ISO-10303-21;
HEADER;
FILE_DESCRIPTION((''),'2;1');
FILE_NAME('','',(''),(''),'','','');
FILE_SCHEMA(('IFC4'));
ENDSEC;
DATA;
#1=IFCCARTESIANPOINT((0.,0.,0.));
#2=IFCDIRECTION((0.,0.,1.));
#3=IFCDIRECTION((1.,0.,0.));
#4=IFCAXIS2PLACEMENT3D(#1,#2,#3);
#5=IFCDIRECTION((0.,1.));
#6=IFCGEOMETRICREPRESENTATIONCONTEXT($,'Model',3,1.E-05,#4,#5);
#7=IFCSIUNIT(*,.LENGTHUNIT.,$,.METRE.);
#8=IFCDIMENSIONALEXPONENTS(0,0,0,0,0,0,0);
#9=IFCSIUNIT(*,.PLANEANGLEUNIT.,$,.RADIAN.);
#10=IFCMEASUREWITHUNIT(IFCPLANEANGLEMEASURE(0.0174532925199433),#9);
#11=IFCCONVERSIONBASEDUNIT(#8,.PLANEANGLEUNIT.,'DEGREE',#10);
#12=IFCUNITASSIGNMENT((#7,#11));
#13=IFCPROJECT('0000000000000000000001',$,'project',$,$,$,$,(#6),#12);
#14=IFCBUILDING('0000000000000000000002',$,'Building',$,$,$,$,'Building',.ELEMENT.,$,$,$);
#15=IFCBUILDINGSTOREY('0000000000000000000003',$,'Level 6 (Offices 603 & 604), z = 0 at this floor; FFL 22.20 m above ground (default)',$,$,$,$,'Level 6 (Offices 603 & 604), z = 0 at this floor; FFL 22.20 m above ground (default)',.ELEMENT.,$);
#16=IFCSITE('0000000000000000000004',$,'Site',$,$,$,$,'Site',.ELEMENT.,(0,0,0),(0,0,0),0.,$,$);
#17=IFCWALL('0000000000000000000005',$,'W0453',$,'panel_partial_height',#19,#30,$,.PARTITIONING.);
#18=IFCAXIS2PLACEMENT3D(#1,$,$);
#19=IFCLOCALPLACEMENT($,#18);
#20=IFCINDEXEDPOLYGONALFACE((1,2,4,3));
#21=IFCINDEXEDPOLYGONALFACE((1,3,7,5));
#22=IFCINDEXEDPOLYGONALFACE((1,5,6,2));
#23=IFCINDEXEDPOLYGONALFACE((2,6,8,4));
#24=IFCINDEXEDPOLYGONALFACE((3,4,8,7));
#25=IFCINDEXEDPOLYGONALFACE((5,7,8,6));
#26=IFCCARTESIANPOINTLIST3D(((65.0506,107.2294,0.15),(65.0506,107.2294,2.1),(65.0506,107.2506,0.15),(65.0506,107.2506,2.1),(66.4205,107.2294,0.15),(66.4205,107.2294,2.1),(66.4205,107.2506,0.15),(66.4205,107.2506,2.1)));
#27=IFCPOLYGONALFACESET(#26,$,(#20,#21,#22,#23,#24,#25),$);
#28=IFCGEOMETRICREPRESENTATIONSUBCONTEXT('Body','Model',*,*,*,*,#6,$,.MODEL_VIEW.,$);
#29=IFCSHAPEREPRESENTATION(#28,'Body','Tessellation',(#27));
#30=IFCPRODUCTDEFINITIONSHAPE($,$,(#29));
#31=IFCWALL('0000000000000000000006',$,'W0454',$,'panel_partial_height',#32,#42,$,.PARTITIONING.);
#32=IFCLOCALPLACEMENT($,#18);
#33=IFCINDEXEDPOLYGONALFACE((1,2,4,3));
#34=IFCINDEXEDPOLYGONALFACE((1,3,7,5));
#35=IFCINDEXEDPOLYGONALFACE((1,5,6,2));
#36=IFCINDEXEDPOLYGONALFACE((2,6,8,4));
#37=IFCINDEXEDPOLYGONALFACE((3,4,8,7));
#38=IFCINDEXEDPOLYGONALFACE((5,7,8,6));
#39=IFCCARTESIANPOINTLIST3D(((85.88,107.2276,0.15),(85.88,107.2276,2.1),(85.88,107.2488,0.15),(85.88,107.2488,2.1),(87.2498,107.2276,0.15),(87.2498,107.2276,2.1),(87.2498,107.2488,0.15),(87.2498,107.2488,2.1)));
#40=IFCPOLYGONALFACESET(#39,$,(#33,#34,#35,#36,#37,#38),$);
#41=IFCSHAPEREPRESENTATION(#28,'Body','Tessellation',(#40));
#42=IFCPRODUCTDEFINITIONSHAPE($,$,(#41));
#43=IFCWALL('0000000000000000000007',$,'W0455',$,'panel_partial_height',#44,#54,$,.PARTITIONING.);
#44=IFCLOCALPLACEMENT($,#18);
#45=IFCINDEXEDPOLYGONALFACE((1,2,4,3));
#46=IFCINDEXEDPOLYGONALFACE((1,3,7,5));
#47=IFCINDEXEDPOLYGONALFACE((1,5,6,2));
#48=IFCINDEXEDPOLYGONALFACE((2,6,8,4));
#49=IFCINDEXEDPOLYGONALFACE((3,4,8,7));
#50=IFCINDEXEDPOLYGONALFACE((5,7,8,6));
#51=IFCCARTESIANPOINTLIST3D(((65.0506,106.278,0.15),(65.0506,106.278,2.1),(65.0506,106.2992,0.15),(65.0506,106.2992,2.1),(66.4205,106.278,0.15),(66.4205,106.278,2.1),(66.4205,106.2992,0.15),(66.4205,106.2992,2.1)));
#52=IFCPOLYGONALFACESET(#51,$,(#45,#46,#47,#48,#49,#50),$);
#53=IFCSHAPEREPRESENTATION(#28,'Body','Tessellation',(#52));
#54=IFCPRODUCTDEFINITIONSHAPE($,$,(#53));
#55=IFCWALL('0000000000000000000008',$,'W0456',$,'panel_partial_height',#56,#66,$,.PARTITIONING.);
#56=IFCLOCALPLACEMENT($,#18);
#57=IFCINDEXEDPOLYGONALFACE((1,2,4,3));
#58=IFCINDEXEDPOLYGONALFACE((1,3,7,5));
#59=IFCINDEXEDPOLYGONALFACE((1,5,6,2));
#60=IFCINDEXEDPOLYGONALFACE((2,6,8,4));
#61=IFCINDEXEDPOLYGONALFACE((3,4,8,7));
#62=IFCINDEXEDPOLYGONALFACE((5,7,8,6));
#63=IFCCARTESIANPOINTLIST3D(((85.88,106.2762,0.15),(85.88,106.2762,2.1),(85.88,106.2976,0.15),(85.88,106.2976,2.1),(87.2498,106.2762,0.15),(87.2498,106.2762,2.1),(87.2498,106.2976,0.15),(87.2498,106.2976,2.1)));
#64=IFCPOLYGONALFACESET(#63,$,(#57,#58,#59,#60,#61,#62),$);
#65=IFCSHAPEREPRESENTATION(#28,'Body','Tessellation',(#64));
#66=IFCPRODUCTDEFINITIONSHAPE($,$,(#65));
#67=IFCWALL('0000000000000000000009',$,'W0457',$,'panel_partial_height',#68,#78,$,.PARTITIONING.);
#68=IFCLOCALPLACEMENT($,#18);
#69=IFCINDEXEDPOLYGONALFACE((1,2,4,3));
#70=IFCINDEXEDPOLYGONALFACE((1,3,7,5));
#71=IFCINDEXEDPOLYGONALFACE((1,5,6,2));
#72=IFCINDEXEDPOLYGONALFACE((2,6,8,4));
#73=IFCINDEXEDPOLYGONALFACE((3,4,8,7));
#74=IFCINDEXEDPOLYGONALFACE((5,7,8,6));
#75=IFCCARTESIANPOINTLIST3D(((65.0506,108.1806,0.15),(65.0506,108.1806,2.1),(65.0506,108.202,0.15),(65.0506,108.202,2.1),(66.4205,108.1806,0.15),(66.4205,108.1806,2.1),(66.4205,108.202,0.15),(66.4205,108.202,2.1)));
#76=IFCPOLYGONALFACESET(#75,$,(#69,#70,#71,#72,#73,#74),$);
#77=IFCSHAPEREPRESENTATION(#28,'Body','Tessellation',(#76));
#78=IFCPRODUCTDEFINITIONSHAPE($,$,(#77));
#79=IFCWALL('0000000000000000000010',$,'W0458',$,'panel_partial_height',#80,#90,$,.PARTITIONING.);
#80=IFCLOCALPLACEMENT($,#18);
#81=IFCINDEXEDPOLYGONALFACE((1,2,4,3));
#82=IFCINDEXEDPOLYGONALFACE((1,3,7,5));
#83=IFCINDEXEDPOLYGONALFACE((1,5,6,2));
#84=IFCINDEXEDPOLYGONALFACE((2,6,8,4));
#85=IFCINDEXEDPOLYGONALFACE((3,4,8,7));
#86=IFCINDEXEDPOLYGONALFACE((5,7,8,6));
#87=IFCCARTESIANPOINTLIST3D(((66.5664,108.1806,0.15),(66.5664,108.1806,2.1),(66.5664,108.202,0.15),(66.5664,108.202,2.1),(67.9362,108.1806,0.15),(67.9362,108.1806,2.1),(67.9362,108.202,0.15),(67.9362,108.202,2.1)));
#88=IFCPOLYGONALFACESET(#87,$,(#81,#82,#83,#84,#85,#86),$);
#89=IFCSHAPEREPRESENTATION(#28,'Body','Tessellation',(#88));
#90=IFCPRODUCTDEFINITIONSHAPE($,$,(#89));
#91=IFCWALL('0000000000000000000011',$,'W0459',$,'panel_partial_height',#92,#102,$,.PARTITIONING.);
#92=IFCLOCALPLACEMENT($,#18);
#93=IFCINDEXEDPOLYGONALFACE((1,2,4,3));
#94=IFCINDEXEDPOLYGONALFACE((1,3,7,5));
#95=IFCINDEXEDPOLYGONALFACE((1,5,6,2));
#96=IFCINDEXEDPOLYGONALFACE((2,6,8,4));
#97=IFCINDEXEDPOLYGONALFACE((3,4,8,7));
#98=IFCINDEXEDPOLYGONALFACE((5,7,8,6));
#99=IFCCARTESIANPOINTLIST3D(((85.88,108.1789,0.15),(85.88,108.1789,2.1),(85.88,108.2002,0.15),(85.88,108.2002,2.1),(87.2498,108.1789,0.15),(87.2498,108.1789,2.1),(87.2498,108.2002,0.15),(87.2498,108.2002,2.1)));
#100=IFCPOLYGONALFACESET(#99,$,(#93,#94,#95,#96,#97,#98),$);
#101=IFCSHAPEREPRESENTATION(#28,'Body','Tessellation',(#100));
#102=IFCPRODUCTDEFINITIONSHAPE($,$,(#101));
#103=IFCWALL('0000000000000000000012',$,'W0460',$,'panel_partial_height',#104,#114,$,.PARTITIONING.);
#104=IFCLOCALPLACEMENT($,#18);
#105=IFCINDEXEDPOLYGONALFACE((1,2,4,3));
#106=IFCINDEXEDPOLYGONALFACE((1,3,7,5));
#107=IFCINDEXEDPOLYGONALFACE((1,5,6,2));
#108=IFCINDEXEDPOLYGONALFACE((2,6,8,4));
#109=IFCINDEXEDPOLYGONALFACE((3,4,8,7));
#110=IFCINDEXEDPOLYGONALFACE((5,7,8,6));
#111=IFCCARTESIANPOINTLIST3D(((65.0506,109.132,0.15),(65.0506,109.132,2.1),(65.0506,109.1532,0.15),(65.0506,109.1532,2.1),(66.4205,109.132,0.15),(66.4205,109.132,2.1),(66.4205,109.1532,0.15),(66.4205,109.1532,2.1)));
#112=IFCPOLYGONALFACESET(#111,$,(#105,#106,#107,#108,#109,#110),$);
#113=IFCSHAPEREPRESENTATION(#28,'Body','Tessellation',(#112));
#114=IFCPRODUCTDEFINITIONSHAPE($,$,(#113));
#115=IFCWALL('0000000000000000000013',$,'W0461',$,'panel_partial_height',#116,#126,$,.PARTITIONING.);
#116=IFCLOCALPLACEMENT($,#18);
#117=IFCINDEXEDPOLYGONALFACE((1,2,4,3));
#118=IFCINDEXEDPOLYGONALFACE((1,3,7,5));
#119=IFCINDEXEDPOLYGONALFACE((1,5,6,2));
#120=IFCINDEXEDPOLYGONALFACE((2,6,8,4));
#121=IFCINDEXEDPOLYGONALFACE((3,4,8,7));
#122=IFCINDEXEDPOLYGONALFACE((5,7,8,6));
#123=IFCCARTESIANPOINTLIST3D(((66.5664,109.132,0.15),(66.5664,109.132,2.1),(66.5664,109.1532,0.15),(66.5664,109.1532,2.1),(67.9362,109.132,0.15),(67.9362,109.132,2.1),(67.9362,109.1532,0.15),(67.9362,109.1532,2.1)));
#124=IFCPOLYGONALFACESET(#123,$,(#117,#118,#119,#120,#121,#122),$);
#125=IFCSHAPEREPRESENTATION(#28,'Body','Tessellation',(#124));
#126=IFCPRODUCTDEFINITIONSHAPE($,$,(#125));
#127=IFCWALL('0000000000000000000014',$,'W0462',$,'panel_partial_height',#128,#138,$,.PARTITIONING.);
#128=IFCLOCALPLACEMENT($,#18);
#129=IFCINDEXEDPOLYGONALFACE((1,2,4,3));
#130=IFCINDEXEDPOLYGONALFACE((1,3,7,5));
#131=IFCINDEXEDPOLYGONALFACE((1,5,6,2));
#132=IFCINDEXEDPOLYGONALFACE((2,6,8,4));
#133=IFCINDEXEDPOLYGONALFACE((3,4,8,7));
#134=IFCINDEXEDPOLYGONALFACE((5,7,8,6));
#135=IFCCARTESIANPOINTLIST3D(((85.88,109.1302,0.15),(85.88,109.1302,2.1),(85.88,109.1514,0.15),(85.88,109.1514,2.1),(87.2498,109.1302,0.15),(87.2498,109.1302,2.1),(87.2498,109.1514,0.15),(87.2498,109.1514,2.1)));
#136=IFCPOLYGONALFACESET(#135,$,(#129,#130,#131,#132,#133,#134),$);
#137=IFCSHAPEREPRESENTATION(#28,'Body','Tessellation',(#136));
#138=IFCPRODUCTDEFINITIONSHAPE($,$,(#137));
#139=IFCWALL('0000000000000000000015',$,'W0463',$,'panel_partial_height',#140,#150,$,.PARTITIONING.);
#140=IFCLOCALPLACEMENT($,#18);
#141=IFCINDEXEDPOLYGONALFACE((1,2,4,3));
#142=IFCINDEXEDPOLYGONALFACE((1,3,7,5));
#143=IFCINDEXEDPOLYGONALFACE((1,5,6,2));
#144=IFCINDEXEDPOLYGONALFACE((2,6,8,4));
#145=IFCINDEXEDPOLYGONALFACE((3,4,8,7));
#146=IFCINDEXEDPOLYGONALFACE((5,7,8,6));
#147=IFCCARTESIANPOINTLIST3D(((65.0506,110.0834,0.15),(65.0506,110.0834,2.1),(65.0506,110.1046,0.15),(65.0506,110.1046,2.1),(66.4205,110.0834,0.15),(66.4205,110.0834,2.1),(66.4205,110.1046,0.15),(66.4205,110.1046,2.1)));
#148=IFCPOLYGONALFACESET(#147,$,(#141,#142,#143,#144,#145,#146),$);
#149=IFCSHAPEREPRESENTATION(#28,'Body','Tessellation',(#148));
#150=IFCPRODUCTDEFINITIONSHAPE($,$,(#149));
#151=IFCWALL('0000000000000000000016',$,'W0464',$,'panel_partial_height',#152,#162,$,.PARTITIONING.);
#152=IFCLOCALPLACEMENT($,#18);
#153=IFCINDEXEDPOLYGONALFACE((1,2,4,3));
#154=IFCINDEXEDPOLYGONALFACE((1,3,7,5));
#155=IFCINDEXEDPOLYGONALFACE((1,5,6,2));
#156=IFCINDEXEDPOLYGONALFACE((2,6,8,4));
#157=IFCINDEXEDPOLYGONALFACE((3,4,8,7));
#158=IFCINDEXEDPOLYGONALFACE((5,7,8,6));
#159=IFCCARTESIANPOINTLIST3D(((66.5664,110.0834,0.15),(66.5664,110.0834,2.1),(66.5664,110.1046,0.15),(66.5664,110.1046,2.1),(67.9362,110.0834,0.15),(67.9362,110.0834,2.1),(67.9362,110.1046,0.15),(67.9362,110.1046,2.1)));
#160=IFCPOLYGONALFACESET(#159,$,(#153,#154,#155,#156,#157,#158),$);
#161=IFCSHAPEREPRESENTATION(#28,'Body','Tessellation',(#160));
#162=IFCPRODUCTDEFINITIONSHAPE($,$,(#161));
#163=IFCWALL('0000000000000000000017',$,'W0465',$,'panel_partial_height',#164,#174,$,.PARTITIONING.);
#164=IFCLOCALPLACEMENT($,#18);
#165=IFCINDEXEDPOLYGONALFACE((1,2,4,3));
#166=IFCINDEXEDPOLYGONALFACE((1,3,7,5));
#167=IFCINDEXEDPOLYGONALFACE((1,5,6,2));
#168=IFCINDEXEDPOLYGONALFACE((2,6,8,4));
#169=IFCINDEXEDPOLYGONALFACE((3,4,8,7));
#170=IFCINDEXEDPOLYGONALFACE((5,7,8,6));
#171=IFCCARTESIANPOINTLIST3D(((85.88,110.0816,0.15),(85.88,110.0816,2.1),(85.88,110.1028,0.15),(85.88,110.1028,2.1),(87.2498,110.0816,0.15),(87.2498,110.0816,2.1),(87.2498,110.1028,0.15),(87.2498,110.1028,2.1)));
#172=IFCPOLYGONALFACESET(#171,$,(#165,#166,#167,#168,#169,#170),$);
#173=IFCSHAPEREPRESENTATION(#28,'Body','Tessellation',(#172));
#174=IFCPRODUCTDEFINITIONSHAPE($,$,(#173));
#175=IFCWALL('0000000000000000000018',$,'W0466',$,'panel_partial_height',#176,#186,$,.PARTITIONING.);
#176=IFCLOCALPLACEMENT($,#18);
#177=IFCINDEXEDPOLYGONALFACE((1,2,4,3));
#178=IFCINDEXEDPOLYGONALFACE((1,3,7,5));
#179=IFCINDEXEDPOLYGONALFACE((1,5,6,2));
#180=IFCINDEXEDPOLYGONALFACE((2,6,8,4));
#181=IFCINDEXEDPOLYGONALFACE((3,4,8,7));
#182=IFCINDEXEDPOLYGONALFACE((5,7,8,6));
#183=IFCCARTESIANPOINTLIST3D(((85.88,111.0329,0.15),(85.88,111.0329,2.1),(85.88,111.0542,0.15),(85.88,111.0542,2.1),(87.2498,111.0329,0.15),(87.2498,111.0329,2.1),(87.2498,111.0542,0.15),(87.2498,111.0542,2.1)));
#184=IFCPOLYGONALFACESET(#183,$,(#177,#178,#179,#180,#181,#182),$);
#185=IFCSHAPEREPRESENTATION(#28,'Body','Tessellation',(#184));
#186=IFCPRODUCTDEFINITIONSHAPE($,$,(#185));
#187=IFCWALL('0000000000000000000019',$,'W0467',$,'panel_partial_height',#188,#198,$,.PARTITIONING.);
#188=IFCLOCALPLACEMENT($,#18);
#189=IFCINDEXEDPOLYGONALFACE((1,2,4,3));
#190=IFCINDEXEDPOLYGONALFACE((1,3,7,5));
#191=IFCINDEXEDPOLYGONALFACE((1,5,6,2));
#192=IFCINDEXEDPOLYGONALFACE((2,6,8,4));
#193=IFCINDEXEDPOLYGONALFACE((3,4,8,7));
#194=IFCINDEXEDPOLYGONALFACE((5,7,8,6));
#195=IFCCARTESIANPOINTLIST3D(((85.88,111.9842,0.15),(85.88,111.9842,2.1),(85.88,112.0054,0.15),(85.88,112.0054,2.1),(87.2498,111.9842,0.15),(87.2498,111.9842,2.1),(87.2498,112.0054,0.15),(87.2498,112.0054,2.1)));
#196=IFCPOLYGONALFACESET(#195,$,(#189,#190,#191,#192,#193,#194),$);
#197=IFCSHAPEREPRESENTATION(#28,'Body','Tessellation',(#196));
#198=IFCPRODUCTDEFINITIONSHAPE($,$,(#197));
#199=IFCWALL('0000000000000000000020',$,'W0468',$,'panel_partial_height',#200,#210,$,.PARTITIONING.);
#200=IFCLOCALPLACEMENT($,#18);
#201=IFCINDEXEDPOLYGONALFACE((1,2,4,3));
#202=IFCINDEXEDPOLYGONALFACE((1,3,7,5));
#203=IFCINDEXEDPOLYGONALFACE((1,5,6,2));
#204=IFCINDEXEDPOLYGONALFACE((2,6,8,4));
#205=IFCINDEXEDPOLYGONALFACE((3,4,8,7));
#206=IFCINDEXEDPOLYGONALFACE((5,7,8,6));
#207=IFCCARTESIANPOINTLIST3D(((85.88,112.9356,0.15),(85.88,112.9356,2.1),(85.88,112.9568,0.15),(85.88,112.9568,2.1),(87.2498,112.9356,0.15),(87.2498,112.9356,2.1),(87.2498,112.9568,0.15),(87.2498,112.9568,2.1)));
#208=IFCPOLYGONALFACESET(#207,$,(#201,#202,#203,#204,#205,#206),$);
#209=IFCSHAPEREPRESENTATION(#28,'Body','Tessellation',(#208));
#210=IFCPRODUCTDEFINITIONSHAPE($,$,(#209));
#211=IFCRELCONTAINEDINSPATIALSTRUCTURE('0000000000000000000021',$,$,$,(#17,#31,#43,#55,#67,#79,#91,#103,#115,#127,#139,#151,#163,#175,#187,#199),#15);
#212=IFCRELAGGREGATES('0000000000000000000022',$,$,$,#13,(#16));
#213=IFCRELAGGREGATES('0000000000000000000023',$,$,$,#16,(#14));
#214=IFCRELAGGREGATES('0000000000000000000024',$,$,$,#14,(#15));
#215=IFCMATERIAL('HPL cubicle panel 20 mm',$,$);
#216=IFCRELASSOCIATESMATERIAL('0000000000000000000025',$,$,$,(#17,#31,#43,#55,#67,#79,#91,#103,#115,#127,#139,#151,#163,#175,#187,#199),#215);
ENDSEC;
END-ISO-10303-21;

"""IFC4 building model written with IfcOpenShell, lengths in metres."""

from ifc_helpers import new_model, entity, si_unit, converted_unit, direction, frame, frame_2d, origin_with_axes, origin_2d_with_axis, place, context, subcontext, project, spatial, rectangle, extrude, material, element, save


model = new_model("IFC4")

# Units and contexts
model_context = context("Model", 3, precision=1e-05, world=origin_with_axes(), true_north=direction((0.0, 1.0)))
body_context = subcontext(model_context, "Body", "Model", "MODEL_VIEW")
ifc_project = project(units=[si_unit("LENGTHUNIT", "METRE"), converted_unit("PLANEANGLEUNIT", "DEGREE", entity("IfcPlaneAngleMeasure", 0.0174532925199433), si_unit("PLANEANGLEUNIT", "RADIAN"), dimensions=[0, 0, 0, 0, 0, 0, 0])], contexts=[model_context])

# Site, building, storey
site = spatial("IfcSite", under=ifc_project, Name="Site", LongName="Site", CompositionType="ELEMENT", RefLatitude=(0, 0, 0), RefLongitude=(0, 0, 0), RefElevation=0.0)
building = spatial("IfcBuilding", under=site, Name="Building", LongName="Building", CompositionType="ELEMENT")
storey = spatial("IfcBuildingStorey", under=building, Name="Level 6 (Offices 603 & 604), z = 0 at this floor; FFL 22.20 m above ground (default)", LongName="Level 6 (Offices 603 & 604), z = 0 at this floor; FFL 22.20 m above ground (default)", CompositionType="ELEMENT")

# Walls
ifc_material_1 = material(Name="HPL cubicle panel 20 mm")
placement = place(None, origin_with_axes())
element("IfcWall", 1, at=placement, inside=storey, material=ifc_material_1, Name="W0453", ObjectType="panel_partial_height", PredefinedType="PARTITIONING", context=body_context, shape_type="SweptSolid", body=[
    extrude(rectangle(XDim=1.3699, YDim=0.0213, at=origin_2d_with_axis()), frame((65.7356, 107.24, 0.15), z_axis=(0.0, 0.0, 1.0), x_axis=(1.0, 0.0, 0.0)), (0.0, 0.0, 1.0), 1.95),
])
element("IfcWall", 2, at=placement, inside=storey, material=ifc_material_1, Name="W0454", ObjectType="panel_partial_height", PredefinedType="PARTITIONING", context=body_context, shape_type="SweptSolid", body=[
    extrude(rectangle(XDim=1.3698, YDim=0.0213, at=frame_2d((0.0, 0.0), x_axis=(1.0, 0.0))), frame((86.5649, 107.2382, 0.15), z_axis=(0.0, 0.0, 1.0), x_axis=(1.0, 0.0, 0.0)), (0.0, 0.0, 1.0), 1.95),
])
element("IfcWall", 3, at=placement, inside=storey, material=ifc_material_1, Name="W0455", ObjectType="panel_partial_height", PredefinedType="PARTITIONING", context=body_context, shape_type="SweptSolid", body=[
    extrude(rectangle(XDim=1.3699, YDim=0.0213, at=origin_2d_with_axis()), frame((65.7356, 106.2886, 0.15), z_axis=(0.0, 0.0, 1.0), x_axis=(1.0, 0.0, 0.0)), (0.0, 0.0, 1.0), 1.95),
])
element("IfcWall", 4, at=placement, inside=storey, material=ifc_material_1, Name="W0456", ObjectType="panel_partial_height", PredefinedType="PARTITIONING", context=body_context, shape_type="SweptSolid", body=[
    extrude(rectangle(XDim=1.3698, YDim=0.0213, at=frame_2d((0.0, 0.0), x_axis=(1.0, 0.0))), frame((86.5649, 106.2869, 0.15), z_axis=(0.0, 0.0, 1.0), x_axis=(1.0, 0.0, 0.0)), (0.0, 0.0, 1.0), 1.95),
])
element("IfcWall", 5, at=placement, inside=storey, material=ifc_material_1, Name="W0457", ObjectType="panel_partial_height", PredefinedType="PARTITIONING", context=body_context, shape_type="SweptSolid", body=[
    extrude(rectangle(XDim=1.3699, YDim=0.0213, at=origin_2d_with_axis()), frame((65.7356, 108.1913, 0.15), z_axis=(0.0, 0.0, 1.0), x_axis=(1.0, 0.0, 0.0)), (0.0, 0.0, 1.0), 1.95),
])
element("IfcWall", 6, at=placement, inside=storey, material=ifc_material_1, Name="W0458", ObjectType="panel_partial_height", PredefinedType="PARTITIONING", context=body_context, shape_type="SweptSolid", body=[
    extrude(rectangle(XDim=1.3698, YDim=0.0213, at=frame_2d((0.0, 0.0), x_axis=(1.0, 0.0))), frame((67.2513, 108.1913, 0.15), z_axis=(0.0, 0.0, 1.0), x_axis=(1.0, 0.0, 0.0)), (0.0, 0.0, 1.0), 1.95),
])
element("IfcWall", 7, at=placement, inside=storey, material=ifc_material_1, Name="W0459", ObjectType="panel_partial_height", PredefinedType="PARTITIONING", context=body_context, shape_type="SweptSolid", body=[
    extrude(rectangle(XDim=1.3698, YDim=0.0213, at=frame_2d((0.0, 0.0), x_axis=(1.0, 0.0))), frame((86.5649, 108.1895, 0.15), z_axis=(0.0, 0.0, 1.0), x_axis=(1.0, 0.0, 0.0)), (0.0, 0.0, 1.0), 1.95),
])
element("IfcWall", 8, at=placement, inside=storey, material=ifc_material_1, Name="W0460", ObjectType="panel_partial_height", PredefinedType="PARTITIONING", context=body_context, shape_type="SweptSolid", body=[
    extrude(rectangle(XDim=1.3699, YDim=0.0213, at=origin_2d_with_axis()), frame((65.7356, 109.1426, 0.15), z_axis=(0.0, 0.0, 1.0), x_axis=(1.0, 0.0, 0.0)), (0.0, 0.0, 1.0), 1.95),
])
element("IfcWall", 9, at=placement, inside=storey, material=ifc_material_1, Name="W0461", ObjectType="panel_partial_height", PredefinedType="PARTITIONING", context=body_context, shape_type="SweptSolid", body=[
    extrude(rectangle(XDim=1.3698, YDim=0.0213, at=frame_2d((0.0, 0.0), x_axis=(1.0, 0.0))), frame((67.2513, 109.1426, 0.15), z_axis=(0.0, 0.0, 1.0), x_axis=(1.0, 0.0, 0.0)), (0.0, 0.0, 1.0), 1.95),
])
element("IfcWall", 10, at=placement, inside=storey, material=ifc_material_1, Name="W0462", ObjectType="panel_partial_height", PredefinedType="PARTITIONING", context=body_context, shape_type="SweptSolid", body=[
    extrude(rectangle(XDim=1.3698, YDim=0.0213, at=frame_2d((0.0, 0.0), x_axis=(1.0, 0.0))), frame((86.5649, 109.1408, 0.15), z_axis=(0.0, 0.0, 1.0), x_axis=(1.0, 0.0, 0.0)), (0.0, 0.0, 1.0), 1.95),
])
element("IfcWall", 11, at=placement, inside=storey, material=ifc_material_1, Name="W0463", ObjectType="panel_partial_height", PredefinedType="PARTITIONING", context=body_context, shape_type="SweptSolid", body=[
    extrude(rectangle(XDim=1.3699, YDim=0.0213, at=origin_2d_with_axis()), frame((65.7356, 110.094, 0.15), z_axis=(0.0, 0.0, 1.0), x_axis=(1.0, 0.0, 0.0)), (0.0, 0.0, 1.0), 1.95),
])
element("IfcWall", 12, at=placement, inside=storey, material=ifc_material_1, Name="W0464", ObjectType="panel_partial_height", PredefinedType="PARTITIONING", context=body_context, shape_type="SweptSolid", body=[
    extrude(rectangle(XDim=1.3698, YDim=0.0213, at=frame_2d((0.0, 0.0), x_axis=(1.0, 0.0))), frame((67.2513, 110.094, 0.15), z_axis=(0.0, 0.0, 1.0), x_axis=(1.0, 0.0, 0.0)), (0.0, 0.0, 1.0), 1.95),
])
element("IfcWall", 13, at=placement, inside=storey, material=ifc_material_1, Name="W0465", ObjectType="panel_partial_height", PredefinedType="PARTITIONING", context=body_context, shape_type="SweptSolid", body=[
    extrude(rectangle(XDim=1.3698, YDim=0.0213, at=frame_2d((0.0, 0.0), x_axis=(1.0, 0.0))), frame((86.5649, 110.0922, 0.15), z_axis=(0.0, 0.0, 1.0), x_axis=(1.0, 0.0, 0.0)), (0.0, 0.0, 1.0), 1.95),
])
element("IfcWall", 14, at=placement, inside=storey, material=ifc_material_1, Name="W0466", ObjectType="panel_partial_height", PredefinedType="PARTITIONING", context=body_context, shape_type="SweptSolid", body=[
    extrude(rectangle(XDim=1.3698, YDim=0.0213, at=frame_2d((0.0, 0.0), x_axis=(1.0, 0.0))), frame((86.5649, 111.0435, 0.15), z_axis=(0.0, 0.0, 1.0), x_axis=(1.0, 0.0, 0.0)), (0.0, 0.0, 1.0), 1.95),
])
element("IfcWall", 15, at=placement, inside=storey, material=ifc_material_1, Name="W0467", ObjectType="panel_partial_height", PredefinedType="PARTITIONING", context=body_context, shape_type="SweptSolid", body=[
    extrude(rectangle(XDim=1.3698, YDim=0.0213, at=frame_2d((0.0, 0.0), x_axis=(1.0, 0.0))), frame((86.5649, 111.9948, 0.15), z_axis=(0.0, 0.0, 1.0), x_axis=(1.0, 0.0, 0.0)), (0.0, 0.0, 1.0), 1.95),
])
element("IfcWall", 16, at=placement, inside=storey, material=ifc_material_1, Name="W0468", ObjectType="panel_partial_height", PredefinedType="PARTITIONING", context=body_context, shape_type="SweptSolid", body=[
    extrude(rectangle(XDim=1.3698, YDim=0.0213, at=frame_2d((0.0, 0.0), x_axis=(1.0, 0.0))), frame((86.5649, 112.9462, 0.15), z_axis=(0.0, 0.0, 1.0), x_axis=(1.0, 0.0, 0.0)), (0.0, 0.0, 1.0), 1.95),
])

save(model, "model.ifc")
